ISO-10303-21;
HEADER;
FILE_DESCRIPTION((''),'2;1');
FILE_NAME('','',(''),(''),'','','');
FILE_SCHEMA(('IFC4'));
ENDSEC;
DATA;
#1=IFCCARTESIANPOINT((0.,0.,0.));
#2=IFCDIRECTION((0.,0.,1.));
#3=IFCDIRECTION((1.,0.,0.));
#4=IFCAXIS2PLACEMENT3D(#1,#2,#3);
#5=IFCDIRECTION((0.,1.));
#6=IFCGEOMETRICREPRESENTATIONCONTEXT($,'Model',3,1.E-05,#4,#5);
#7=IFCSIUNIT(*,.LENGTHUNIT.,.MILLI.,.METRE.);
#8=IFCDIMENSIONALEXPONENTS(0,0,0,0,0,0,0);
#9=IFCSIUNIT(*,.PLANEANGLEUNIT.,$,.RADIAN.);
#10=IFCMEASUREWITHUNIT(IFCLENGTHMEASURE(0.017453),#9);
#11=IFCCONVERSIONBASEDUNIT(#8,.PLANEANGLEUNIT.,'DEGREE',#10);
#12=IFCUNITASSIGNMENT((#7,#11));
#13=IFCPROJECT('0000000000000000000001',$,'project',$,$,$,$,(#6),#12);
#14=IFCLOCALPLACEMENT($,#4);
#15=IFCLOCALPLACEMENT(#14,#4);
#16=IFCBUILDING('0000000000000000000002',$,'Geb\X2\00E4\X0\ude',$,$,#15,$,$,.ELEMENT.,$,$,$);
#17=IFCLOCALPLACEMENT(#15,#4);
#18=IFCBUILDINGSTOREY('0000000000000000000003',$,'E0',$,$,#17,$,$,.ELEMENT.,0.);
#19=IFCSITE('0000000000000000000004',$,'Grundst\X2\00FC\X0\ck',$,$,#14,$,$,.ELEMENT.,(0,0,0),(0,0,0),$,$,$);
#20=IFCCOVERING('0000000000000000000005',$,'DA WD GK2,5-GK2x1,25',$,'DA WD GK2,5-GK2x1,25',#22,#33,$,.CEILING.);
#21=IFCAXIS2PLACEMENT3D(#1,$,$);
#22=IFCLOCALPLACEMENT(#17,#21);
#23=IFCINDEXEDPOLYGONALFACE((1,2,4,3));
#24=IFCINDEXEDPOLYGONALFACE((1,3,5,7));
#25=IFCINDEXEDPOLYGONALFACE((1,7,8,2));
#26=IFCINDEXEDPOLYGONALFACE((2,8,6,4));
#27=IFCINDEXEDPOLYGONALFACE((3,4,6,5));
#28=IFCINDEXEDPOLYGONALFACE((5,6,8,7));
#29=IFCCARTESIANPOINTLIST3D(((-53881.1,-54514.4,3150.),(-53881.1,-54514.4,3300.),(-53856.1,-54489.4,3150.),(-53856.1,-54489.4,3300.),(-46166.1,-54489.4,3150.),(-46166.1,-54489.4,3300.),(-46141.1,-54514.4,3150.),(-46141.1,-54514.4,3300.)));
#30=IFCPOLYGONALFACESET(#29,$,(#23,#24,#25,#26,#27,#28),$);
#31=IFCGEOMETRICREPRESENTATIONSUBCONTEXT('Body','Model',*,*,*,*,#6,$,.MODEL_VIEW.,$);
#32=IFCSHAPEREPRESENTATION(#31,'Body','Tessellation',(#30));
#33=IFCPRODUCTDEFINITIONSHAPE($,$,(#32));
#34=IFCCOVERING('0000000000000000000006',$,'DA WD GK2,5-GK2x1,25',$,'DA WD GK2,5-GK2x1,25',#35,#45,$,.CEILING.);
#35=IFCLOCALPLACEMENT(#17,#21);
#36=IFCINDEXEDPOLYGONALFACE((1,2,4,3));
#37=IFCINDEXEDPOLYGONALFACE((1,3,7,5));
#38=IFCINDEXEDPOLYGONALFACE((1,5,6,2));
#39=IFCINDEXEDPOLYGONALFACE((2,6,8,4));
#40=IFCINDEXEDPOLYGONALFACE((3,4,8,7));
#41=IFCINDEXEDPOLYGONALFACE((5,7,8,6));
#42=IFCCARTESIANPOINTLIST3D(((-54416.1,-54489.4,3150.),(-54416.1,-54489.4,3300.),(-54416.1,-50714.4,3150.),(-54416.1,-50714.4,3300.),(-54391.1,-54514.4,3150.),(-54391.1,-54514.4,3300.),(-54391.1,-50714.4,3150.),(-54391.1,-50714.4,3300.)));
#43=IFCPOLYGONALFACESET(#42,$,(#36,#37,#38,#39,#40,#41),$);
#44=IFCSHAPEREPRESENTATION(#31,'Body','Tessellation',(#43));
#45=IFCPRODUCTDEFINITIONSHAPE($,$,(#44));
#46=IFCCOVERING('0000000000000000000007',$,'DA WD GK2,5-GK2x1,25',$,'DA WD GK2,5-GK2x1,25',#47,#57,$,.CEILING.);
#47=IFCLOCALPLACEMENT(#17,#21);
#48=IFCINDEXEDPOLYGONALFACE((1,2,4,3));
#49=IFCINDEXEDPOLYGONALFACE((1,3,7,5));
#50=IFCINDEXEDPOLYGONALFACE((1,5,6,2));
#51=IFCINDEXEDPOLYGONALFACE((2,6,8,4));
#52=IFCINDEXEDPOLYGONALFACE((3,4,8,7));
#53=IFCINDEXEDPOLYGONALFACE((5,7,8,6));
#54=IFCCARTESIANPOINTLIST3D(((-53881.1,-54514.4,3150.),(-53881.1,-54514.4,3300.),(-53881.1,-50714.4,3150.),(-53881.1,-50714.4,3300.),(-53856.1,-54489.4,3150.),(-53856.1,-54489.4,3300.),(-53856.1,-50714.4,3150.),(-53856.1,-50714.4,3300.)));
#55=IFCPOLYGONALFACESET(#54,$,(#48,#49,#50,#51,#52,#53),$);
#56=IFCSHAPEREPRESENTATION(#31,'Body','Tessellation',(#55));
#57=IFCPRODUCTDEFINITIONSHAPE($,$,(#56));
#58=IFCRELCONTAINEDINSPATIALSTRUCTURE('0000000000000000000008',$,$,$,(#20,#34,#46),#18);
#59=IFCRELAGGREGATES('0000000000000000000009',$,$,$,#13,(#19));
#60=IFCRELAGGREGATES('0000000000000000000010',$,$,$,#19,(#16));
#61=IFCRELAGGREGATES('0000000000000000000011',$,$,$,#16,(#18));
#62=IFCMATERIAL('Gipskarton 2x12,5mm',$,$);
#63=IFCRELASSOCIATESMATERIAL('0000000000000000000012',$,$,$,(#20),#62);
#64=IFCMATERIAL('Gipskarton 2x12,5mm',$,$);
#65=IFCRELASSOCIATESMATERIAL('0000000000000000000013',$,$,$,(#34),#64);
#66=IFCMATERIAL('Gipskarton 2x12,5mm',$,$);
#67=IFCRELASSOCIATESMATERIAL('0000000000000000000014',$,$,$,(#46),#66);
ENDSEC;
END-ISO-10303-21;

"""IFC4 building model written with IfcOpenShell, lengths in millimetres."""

from ifc_helpers import new_model, entity, si_unit, converted_unit, direction, frame, origin_with_axes, place, context, subcontext, project, spatial, line, indexed_curve, outline, extrude, material, element, save


model = new_model("IFC4")

# Units and contexts
model_context = context("Model", 3, precision=1e-05, world=origin_with_axes(), true_north=direction((0.0, 1.0)))
body_context = subcontext(model_context, "Body", "Model", "MODEL_VIEW")
ifc_project = project(units=[si_unit("LENGTHUNIT", "METRE", prefix="MILLI"), converted_unit("PLANEANGLEUNIT", "DEGREE", entity("IfcLengthMeasure", 0.017453), si_unit("PLANEANGLEUNIT", "RADIAN"), dimensions=[0, 0, 0, 0, 0, 0, 0])], contexts=[model_context])

# Site, building, storey
site_placement = place(None, origin_with_axes())
site = spatial("IfcSite", under=ifc_project, at=site_placement, Name="Grundstück", CompositionType="ELEMENT", RefLatitude=(0, 0, 0), RefLongitude=(0, 0, 0))
building_placement = place(site_placement, origin_with_axes())
building = spatial("IfcBuilding", under=site, at=building_placement, Name="Gebäude", CompositionType="ELEMENT")
storey_placement = place(building_placement, origin_with_axes())
storey = spatial("IfcBuildingStorey", under=building, at=storey_placement, Name="E0", CompositionType="ELEMENT", Elevation=0.0)

# Coverings
ifc_material_1 = material(Name="Gipskarton 2x12,5mm")
covering_1_placement = place(storey_placement, frame((-53868.6, -54501.9, 3150.0), z_axis=(0.0, 0.0, 1.0), x_axis=(1.0, 0.0, 0.0)))
element("IfcCovering", 1, at=covering_1_placement, inside=storey, material=ifc_material_1, Name="DA WD GK2,5-GK2x1,25", ObjectType="DA WD GK2,5-GK2x1,25", PredefinedType="CEILING", context=body_context, shape_type="SweptSolid", body=[
    extrude(outline(indexed_curve([(-12.5, -12.5), (12.5, 12.5), (7702.5, 12.5), (7727.5, -12.5)], segments=[line(1, 2), line(2, 3), line(3, 4), line(4, 1)])), origin_with_axes(), (0.0, 0.0, 1.0), 150.0),
])
ifc_material_2 = material(Name="Gipskarton 2x12,5mm")
covering_2_placement = place(storey_placement, frame((-54403.6, -54501.9, 3150.0), z_axis=(0.0, 0.0, 1.0), x_axis=(0.0, 1.0, 0.0)))
element("IfcCovering", 2, at=covering_2_placement, inside=storey, material=ifc_material_2, Name="DA WD GK2,5-GK2x1,25", ObjectType="DA WD GK2,5-GK2x1,25", PredefinedType="CEILING", context=body_context, shape_type="SweptSolid", body=[
    extrude(outline(indexed_curve([(-12.5, -12.5), (12.5, 12.5), (3787.5, 12.5), (3787.5, -12.5)], segments=[line(1, 2), line(2, 3), line(3, 4), line(4, 1)])), origin_with_axes(), (0.0, 0.0, 1.0), 150.0),
])
ifc_material_3 = material(Name="Gipskarton 2x12,5mm")
covering_3_placement = place(storey_placement, frame((-53868.6, -54501.9, 3150.0), z_axis=(0.0, 0.0, 1.0), x_axis=(0.0, 1.0, 0.0)))
element("IfcCovering", 3, at=covering_3_placement, inside=storey, material=ifc_material_3, Name="DA WD GK2,5-GK2x1,25", ObjectType="DA WD GK2,5-GK2x1,25", PredefinedType="CEILING", context=body_context, shape_type="SweptSolid", body=[
    extrude(outline(indexed_curve([(12.5, -12.5), (-12.5, 12.5), (3787.5, 12.5), (3787.5, -12.5)], segments=[line(1, 2), line(2, 3), line(3, 4), line(4, 1)])), origin_with_axes(), (0.0, 0.0, 1.0), 150.0),
])

save(model, "model.ifc")
